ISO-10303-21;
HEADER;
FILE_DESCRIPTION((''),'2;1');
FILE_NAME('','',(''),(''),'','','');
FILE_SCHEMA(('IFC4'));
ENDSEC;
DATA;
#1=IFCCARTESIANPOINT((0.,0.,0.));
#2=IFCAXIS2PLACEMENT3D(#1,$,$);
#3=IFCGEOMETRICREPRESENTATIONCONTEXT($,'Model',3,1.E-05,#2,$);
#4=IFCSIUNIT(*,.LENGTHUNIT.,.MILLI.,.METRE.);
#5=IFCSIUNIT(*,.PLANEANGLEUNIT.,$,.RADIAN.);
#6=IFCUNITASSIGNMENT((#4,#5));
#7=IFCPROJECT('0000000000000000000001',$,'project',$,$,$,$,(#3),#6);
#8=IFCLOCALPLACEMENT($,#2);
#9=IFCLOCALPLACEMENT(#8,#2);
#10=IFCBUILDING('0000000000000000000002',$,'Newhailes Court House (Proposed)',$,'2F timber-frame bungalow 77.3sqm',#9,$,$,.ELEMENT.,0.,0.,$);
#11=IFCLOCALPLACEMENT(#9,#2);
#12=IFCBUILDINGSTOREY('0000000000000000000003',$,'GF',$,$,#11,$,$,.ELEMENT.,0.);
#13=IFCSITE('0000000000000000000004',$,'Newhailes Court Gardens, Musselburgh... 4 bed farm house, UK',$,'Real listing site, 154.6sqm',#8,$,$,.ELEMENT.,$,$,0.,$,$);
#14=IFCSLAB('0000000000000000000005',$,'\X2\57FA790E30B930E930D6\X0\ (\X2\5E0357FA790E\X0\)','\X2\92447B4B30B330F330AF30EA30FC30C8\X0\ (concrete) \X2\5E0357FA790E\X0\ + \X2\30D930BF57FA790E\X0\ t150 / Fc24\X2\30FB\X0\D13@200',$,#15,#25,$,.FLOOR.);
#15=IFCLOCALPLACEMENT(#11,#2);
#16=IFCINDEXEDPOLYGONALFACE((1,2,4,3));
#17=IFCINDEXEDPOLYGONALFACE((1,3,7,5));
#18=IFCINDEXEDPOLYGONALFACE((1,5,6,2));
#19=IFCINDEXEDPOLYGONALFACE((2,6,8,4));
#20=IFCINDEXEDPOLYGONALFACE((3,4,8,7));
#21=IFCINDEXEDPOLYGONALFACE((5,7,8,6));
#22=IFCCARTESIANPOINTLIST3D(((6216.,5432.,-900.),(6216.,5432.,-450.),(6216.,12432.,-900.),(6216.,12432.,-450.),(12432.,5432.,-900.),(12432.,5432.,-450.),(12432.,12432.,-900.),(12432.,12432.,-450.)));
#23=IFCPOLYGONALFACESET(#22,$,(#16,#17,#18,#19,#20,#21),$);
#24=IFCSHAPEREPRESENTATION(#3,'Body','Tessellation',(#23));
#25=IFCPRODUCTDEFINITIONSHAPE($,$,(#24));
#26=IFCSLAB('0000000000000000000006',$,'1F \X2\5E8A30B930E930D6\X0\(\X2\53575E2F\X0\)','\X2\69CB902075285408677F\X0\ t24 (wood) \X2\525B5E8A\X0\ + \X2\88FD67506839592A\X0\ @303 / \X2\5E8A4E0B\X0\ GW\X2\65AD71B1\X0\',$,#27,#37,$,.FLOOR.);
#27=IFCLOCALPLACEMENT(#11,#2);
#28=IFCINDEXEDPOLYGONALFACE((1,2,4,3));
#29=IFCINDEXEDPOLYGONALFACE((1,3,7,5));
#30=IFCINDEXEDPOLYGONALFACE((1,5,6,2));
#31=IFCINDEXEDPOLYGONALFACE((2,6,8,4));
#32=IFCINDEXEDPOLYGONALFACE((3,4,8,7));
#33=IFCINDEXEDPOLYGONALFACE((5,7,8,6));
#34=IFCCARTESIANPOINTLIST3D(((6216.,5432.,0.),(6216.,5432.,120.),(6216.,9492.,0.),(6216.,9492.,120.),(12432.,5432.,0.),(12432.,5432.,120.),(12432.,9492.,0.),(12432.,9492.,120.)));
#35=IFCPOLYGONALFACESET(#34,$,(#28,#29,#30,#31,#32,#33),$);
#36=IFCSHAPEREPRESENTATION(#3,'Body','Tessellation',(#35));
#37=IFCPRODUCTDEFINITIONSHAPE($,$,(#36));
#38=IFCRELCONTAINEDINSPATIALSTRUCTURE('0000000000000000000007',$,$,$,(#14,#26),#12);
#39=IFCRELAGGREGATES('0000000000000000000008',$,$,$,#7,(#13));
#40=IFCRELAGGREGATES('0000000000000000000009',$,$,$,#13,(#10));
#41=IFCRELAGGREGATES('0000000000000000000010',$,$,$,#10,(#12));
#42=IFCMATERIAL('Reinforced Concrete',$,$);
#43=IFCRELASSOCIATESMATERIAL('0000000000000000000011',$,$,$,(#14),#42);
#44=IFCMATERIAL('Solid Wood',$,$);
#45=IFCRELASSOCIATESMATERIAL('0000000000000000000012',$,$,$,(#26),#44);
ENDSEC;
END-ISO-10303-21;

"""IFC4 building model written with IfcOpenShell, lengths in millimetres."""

from ifc_helpers import new_model, si_unit, frame, frame_2d, origin, place, context, project, spatial, rectangle, extrude, material, element, save


model = new_model("IFC4")

# Units and contexts
model_context = context("Model", 3, precision=1e-05, world=origin())
ifc_project = project(units=[si_unit("LENGTHUNIT", "METRE", prefix="MILLI"), si_unit("PLANEANGLEUNIT", "RADIAN")], contexts=[model_context])

# Site, building, storey
site_placement = place(None, origin())
site = spatial("IfcSite", under=ifc_project, at=site_placement, Name="Newhailes Court Gardens, Musselburgh... 4 bed farm house, UK", ObjectType="Real listing site, 154.6sqm", CompositionType="ELEMENT", RefElevation=0.0)
building_placement = place(site_placement, origin())
building = spatial("IfcBuilding", under=site, at=building_placement, Name="Newhailes Court House (Proposed)", ObjectType="2F timber-frame bungalow 77.3sqm", CompositionType="ELEMENT", ElevationOfRefHeight=0.0, ElevationOfTerrain=0.0)
storey_placement = place(building_placement, origin())
storey = spatial("IfcBuildingStorey", under=building, at=storey_placement, Name="GF", CompositionType="ELEMENT", Elevation=0.0)

# Slabs
ifc_material_1 = material(Name="Reinforced Concrete")
slab_1_placement = place(storey_placement, frame((3108.0, 2716.0, -450.0)))
element("IfcSlab", 1, at=slab_1_placement, inside=storey, material=ifc_material_1, Name="基礎スラブ (布基礎)", Description="鉄筋コンクリート (concrete) 布基礎 + ベタ基礎 t150 / Fc24・D13@200", PredefinedType="FLOOR", context=model_context, shape_type="SweptSolid", body=[
    extrude(rectangle(XDim=6216.0, YDim=7000.0, at=frame_2d((3108.0, 3500.0))), frame((3108.0, 2716.0, -450.0)), (0.0, 0.0, 1.0), 450.0),
])
ifc_material_2 = material(Name="Solid Wood")
slab_2_placement = place(storey_placement, frame((3108.0, 2716.0, 0.0)))
element("IfcSlab", 2, at=slab_2_placement, inside=storey, material=ifc_material_2, Name="1F 床スラブ(南帯)", Description="構造用合板 t24 (wood) 剛床 + 製材根太 @303 / 床下 GW断熱", PredefinedType="FLOOR", context=model_context, shape_type="SweptSolid", body=[
    extrude(rectangle(XDim=6216.0, YDim=4060.0, at=frame_2d((3108.0, 2030.0))), frame((3108.0, 2716.0, 0.0)), (0.0, 0.0, 1.0), 120.0),
])

save(model, "model.ifc")
